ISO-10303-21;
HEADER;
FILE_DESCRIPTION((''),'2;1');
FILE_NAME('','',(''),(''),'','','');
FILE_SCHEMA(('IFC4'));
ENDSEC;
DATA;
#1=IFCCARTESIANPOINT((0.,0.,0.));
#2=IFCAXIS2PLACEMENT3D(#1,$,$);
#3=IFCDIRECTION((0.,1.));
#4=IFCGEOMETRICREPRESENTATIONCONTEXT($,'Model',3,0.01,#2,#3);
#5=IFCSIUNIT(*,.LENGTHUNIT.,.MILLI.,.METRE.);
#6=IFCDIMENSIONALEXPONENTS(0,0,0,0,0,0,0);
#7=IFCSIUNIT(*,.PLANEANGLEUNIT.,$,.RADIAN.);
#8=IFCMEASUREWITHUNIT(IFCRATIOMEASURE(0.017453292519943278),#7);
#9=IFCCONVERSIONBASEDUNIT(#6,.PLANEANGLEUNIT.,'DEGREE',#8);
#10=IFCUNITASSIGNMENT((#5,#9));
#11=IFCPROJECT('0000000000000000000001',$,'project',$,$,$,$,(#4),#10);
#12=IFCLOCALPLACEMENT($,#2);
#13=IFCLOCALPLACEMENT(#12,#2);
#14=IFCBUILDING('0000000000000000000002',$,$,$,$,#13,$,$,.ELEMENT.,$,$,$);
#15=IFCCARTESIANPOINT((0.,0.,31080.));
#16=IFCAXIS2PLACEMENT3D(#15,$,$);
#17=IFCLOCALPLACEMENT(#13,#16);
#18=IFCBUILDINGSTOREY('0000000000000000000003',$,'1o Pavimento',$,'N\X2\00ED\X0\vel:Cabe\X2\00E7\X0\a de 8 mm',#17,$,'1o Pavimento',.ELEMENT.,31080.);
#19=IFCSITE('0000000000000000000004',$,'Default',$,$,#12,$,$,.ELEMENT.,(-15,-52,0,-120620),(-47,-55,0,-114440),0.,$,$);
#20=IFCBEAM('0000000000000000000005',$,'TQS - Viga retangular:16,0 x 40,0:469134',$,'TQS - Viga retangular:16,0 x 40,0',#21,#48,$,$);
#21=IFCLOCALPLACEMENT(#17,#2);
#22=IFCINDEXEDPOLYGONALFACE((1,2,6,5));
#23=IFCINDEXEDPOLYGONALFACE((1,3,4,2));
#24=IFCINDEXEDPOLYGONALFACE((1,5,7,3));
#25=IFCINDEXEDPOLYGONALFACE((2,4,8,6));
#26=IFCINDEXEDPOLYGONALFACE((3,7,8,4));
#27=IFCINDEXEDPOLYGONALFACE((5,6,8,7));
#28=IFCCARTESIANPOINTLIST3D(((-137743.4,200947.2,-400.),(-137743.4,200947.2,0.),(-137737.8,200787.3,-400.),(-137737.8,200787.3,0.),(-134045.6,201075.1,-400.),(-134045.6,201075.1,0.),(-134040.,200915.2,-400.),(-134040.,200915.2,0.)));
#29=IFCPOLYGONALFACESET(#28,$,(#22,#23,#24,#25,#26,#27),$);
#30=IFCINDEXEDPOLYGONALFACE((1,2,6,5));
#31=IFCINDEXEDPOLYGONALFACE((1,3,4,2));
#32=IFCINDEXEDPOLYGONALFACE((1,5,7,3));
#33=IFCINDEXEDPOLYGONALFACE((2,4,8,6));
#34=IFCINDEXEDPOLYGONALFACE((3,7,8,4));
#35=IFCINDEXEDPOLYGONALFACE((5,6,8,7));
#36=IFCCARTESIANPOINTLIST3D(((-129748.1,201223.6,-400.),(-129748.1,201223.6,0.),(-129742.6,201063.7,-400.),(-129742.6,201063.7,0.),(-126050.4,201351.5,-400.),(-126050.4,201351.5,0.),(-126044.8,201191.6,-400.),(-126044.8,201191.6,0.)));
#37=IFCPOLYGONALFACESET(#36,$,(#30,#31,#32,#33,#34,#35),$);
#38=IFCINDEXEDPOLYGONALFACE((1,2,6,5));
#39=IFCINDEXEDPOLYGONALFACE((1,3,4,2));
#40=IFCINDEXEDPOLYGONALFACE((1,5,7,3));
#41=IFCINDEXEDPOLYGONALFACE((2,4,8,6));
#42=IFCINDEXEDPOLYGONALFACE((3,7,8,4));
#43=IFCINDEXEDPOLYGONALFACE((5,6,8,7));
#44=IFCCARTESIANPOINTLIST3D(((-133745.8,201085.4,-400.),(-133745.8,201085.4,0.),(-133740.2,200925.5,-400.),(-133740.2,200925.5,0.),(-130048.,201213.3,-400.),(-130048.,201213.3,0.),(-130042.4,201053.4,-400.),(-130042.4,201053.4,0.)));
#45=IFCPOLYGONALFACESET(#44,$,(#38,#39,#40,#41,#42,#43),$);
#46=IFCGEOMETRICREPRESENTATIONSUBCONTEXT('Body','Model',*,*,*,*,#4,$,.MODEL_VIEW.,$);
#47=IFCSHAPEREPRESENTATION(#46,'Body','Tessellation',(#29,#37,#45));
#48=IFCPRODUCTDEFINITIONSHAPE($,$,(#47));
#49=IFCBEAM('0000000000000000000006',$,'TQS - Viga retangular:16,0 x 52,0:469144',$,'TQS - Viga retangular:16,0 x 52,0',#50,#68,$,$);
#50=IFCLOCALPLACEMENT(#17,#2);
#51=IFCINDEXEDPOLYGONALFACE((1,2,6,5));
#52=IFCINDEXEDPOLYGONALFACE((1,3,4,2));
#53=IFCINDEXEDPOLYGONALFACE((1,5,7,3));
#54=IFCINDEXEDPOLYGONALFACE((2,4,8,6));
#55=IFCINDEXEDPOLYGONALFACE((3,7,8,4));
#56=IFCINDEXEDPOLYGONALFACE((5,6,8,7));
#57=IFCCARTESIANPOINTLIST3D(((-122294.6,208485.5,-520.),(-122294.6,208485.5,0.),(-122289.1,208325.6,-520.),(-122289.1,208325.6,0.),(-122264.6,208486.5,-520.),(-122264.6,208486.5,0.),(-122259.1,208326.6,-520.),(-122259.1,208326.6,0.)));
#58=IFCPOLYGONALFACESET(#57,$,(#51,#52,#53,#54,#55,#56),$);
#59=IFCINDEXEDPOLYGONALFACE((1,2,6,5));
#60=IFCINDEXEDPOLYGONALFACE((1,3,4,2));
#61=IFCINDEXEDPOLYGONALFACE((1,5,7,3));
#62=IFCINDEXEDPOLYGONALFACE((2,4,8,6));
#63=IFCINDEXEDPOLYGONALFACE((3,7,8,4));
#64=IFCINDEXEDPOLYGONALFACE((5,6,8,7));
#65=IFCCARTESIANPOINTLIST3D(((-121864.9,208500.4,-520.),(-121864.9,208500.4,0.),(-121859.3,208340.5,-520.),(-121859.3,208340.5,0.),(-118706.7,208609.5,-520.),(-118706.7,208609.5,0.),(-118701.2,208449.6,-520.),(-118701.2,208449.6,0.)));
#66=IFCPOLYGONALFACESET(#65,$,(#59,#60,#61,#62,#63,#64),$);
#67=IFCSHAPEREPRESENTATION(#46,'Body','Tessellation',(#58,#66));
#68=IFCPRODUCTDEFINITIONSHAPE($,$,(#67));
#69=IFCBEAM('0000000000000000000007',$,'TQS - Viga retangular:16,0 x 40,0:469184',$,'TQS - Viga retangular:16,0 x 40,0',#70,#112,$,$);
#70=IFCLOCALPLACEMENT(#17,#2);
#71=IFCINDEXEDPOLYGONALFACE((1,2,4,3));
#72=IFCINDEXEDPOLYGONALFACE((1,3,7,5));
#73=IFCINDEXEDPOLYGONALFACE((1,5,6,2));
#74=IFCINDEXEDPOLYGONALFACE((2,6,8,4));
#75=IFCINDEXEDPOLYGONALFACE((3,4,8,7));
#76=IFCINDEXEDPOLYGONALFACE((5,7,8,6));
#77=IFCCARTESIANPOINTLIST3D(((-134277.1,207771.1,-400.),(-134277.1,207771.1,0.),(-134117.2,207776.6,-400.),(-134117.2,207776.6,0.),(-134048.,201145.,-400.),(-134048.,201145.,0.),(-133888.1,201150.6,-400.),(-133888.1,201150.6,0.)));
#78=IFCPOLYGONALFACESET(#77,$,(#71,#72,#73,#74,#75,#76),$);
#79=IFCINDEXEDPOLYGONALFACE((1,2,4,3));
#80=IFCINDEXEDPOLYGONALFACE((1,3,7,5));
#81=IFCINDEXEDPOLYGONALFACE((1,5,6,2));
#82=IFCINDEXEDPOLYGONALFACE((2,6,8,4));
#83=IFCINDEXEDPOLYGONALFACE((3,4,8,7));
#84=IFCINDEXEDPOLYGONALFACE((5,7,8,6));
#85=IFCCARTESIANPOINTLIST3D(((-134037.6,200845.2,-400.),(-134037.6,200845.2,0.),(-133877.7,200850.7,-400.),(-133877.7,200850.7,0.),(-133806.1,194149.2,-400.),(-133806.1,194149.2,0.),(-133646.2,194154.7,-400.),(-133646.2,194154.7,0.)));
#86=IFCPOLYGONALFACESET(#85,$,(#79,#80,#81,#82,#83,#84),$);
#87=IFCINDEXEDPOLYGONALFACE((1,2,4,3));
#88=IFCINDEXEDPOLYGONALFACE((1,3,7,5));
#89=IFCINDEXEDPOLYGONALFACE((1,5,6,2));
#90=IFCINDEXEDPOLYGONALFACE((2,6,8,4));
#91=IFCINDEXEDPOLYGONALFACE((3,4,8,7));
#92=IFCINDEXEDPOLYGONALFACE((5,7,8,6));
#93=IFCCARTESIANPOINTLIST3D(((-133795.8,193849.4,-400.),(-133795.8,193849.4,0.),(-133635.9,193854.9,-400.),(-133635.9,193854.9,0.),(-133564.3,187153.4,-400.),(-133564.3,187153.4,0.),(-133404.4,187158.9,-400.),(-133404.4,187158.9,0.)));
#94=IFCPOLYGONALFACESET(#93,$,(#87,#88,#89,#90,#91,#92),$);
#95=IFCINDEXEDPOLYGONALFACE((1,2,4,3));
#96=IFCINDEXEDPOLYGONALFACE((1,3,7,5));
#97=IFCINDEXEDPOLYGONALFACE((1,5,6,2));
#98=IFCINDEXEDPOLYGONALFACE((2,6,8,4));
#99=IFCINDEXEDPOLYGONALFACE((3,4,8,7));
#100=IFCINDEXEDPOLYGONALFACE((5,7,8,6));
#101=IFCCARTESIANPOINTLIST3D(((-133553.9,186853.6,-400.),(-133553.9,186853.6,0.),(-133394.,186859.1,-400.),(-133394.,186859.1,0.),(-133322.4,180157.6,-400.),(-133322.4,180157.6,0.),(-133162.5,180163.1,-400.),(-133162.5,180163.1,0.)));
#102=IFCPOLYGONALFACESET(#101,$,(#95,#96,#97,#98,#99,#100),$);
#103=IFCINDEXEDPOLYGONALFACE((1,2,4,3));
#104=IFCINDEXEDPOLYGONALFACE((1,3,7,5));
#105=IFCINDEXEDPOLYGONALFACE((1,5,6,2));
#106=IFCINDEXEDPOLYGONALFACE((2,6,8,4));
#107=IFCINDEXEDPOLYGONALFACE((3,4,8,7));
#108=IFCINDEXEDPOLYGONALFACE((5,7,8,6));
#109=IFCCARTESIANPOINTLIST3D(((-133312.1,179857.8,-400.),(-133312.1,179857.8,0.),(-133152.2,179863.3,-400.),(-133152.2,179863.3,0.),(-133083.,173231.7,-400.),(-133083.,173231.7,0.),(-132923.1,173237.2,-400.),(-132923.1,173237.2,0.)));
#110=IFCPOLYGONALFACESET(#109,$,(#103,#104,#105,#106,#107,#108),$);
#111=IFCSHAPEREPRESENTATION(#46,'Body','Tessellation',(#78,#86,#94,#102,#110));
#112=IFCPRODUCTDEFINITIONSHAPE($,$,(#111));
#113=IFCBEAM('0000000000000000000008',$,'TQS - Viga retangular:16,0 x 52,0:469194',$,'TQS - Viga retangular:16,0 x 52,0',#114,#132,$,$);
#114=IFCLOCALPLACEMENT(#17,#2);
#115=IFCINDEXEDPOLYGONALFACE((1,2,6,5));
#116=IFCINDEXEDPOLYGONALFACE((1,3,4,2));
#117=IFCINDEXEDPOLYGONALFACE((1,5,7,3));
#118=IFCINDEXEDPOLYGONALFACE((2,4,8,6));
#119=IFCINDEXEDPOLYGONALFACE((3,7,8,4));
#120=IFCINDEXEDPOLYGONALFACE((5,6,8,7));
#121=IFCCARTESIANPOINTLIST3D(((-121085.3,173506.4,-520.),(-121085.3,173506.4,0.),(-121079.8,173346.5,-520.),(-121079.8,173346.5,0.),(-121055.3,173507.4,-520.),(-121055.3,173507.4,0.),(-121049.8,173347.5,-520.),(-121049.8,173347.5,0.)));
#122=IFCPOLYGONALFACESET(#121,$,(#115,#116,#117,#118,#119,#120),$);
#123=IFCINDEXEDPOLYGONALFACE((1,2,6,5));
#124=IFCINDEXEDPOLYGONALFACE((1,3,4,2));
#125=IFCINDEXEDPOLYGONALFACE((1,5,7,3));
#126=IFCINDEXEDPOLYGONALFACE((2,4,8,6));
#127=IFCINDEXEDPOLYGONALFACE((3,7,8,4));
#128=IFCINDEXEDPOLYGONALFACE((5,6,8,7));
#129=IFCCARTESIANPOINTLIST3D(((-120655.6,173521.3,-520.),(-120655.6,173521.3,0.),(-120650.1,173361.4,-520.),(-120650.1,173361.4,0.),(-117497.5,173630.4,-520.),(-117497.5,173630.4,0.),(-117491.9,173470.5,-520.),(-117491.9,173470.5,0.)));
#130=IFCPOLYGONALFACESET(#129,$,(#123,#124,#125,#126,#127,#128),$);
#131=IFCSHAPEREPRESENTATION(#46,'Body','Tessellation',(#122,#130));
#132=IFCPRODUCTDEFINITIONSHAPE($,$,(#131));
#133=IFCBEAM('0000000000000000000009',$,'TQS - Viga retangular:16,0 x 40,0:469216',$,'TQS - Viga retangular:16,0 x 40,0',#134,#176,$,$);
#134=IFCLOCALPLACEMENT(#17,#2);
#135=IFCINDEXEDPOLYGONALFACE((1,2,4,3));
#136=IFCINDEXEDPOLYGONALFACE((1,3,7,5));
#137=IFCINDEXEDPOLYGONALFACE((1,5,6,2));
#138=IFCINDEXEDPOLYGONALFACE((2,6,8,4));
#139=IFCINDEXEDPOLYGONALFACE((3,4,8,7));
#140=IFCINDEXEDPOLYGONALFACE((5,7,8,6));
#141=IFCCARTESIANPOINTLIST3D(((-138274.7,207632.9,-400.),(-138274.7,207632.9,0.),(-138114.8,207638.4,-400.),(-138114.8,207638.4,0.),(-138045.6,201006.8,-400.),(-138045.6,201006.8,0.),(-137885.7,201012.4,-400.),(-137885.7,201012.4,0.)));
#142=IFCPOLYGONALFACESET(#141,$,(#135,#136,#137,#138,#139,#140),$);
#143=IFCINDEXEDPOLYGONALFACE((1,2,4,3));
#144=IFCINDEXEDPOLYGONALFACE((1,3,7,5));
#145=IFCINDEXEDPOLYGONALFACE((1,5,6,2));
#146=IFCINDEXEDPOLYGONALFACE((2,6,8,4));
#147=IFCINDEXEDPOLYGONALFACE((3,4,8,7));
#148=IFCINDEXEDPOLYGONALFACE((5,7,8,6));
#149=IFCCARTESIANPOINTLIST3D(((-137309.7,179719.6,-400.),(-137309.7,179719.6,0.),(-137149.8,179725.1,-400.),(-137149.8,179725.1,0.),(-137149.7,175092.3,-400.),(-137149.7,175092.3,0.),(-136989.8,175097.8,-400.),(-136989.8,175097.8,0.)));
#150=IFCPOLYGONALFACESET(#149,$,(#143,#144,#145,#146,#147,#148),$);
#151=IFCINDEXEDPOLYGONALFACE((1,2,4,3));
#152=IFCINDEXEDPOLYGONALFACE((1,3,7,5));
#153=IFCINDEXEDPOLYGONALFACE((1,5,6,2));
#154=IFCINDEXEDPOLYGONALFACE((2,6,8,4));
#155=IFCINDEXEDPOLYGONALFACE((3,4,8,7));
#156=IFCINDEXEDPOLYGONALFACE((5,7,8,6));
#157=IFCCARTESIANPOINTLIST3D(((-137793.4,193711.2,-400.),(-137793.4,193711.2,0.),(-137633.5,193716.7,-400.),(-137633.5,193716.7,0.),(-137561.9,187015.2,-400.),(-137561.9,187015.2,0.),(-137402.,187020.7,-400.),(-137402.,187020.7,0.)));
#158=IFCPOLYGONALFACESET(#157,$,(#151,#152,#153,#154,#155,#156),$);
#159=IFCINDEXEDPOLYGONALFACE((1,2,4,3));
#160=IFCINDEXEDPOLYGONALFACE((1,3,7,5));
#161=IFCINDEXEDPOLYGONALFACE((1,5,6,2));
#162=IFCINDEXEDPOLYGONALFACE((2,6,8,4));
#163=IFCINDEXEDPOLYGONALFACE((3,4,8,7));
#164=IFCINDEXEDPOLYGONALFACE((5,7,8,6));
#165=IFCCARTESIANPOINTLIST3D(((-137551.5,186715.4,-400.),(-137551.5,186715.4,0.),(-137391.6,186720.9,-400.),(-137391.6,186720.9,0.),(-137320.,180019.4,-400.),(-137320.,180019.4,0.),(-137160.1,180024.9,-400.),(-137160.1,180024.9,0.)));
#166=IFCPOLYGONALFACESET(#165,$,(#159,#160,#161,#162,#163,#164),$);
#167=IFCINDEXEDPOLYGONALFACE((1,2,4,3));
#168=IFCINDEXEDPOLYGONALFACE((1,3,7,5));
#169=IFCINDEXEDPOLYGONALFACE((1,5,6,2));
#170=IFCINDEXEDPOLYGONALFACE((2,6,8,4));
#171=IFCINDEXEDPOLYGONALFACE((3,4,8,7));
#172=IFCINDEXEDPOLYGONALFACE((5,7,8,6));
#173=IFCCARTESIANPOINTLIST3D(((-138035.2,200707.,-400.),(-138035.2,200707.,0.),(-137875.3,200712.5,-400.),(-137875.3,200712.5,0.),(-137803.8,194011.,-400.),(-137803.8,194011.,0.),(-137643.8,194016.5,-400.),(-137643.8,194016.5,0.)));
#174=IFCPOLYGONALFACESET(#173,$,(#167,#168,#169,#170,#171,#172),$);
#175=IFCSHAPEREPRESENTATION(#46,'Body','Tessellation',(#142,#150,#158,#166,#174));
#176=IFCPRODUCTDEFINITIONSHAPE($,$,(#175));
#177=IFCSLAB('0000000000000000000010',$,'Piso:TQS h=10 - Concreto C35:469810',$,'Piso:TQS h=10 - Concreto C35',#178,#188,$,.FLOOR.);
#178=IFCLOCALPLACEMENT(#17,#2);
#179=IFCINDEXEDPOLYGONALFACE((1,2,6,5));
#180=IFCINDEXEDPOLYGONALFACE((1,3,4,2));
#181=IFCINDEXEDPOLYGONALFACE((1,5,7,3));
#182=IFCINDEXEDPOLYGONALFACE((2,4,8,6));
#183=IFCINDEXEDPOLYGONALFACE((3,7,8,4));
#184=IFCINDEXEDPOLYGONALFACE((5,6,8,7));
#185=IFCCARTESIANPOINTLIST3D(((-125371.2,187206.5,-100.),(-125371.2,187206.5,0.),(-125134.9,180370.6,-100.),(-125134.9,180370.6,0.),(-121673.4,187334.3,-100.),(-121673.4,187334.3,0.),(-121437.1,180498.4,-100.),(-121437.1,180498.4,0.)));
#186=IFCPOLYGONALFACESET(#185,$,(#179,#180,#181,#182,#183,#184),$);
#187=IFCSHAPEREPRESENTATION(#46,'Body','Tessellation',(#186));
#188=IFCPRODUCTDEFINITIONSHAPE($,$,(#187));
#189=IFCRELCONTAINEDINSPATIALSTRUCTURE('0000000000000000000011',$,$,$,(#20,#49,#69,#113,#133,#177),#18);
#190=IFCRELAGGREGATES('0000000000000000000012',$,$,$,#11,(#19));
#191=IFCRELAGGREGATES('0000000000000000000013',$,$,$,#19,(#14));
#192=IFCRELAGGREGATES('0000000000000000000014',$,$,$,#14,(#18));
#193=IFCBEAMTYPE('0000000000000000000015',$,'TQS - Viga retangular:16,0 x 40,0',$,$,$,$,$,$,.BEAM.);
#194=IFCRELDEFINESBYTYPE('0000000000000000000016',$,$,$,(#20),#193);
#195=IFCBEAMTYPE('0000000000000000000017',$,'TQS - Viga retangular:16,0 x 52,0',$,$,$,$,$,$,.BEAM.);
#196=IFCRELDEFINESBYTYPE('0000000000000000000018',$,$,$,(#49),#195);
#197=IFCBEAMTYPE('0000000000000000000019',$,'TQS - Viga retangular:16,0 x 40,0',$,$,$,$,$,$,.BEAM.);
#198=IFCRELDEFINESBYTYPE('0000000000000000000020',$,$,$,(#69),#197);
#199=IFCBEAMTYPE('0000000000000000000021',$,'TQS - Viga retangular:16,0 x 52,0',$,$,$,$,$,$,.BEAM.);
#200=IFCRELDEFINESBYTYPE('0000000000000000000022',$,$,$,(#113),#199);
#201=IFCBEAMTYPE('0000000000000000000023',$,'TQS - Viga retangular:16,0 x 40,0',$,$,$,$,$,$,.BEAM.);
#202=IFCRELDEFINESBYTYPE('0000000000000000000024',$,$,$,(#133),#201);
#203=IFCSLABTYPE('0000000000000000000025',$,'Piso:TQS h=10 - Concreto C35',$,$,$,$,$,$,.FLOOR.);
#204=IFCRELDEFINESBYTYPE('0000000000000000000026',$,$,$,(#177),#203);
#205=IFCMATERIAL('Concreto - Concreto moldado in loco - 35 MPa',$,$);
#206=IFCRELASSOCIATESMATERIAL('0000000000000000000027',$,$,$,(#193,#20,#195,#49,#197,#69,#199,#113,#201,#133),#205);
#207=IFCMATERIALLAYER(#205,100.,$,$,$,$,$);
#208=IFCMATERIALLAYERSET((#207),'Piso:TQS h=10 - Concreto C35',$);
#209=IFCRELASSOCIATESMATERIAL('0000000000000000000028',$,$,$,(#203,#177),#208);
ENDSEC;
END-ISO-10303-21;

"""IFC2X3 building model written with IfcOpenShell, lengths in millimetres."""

from ifc_helpers import new_model, entity, si_unit, converted_unit, direction, frame, frame_2d, origin, place, context, subcontext, project, spatial, rectangle, extrude, source, transform, mapped, material, layer, layer_set, layer_usage, type_object, type_shapes, element, save


model = new_model("IFC2X3")

# Units and contexts
model_context = context("Model", 3, precision=0.01, world=origin(), true_north=direction((0.0, 1.0)))
body_context = subcontext(model_context, "Body", "Model", "MODEL_VIEW")
ifc_project = project(units=[si_unit("LENGTHUNIT", "METRE", prefix="MILLI"), converted_unit("PLANEANGLEUNIT", "DEGREE", entity("IfcRatioMeasure", 0.017453292519943278), si_unit("PLANEANGLEUNIT", "RADIAN"), dimensions=[0, 0, 0, 0, 0, 0, 0])], contexts=[model_context])

# Site, building, storey
site_placement = place(None, origin())
site = spatial("IfcSite", under=ifc_project, at=site_placement, Name="Default", CompositionType="ELEMENT", RefLatitude=(-15, -52, 0, -120620), RefLongitude=(-47, -55, 0, -114440), RefElevation=0.0)
building_placement = place(site_placement, origin())
building = spatial("IfcBuilding", under=site, at=building_placement, CompositionType="ELEMENT")
storey_placement = place(building_placement, frame((0.0, 0.0, 31080.0)))
storey = spatial("IfcBuildingStorey", under=building, at=storey_placement, Name="1o Pavimento", ObjectType="Nível:Cabeça de 8 mm", LongName="1o Pavimento", CompositionType="ELEMENT", Elevation=31080.0)

# Shared definitions
ifc_material = material(Name="Concreto - Concreto moldado in loco - 35 MPa")

# Beams
beam_type_1 = type_object("IfcBeamType", Name="TQS - Viga retangular:16,0 x 40,0", PredefinedType="BEAM", material=ifc_material)
shared_shape_1 = source(origin(), body_context, "Body", "SweptSolid", [
    extrude(rectangle(XDim=400.0, YDim=160.0, at=frame_2d((0.0, 0.0), x_axis=(1.0, 0.0))), frame((-134042.8, 200995.1, 30880.0), z_axis=(-0.999403, -0.034551, 0.0), x_axis=(0.0, 0.0, -1.0)), (0.0, 0.0, 1.0), 3700.0),
    extrude(rectangle(XDim=400.0, YDim=160.0, at=frame_2d((0.0, 0.0), x_axis=(1.0, 0.0))), frame((-126047.6, 201271.5, 30880.0), z_axis=(-0.999403, -0.034551, 0.0), x_axis=(0.0, 0.0, -1.0)), (0.0, 0.0, 1.0), 3700.0),
    extrude(rectangle(XDim=400.0, YDim=160.0, at=frame_2d((0.0, 0.0), x_axis=(1.0, 0.0))), frame((-130045.2, 201133.3, 30880.0), z_axis=(-0.999403, -0.034551, 0.0), x_axis=(0.0, 0.0, -1.0)), (0.0, 0.0, 1.0), 3700.0),
])
type_shapes(beam_type_1, [shared_shape_1])
beam_1_placement = place(storey_placement, frame((0.0, 0.0, -31080.0)))
element("IfcBeam", 1, at=beam_1_placement, inside=storey, type_object=beam_type_1, material=ifc_material, Name="TQS - Viga retangular:16,0 x 40,0:469134", ObjectType="TQS - Viga retangular:16,0 x 40,0", context=body_context, shape_type="MappedRepresentation", body=[
    mapped(shared_shape_1, transform((0.0, 0.0, 0.0), scale=1.0)),
])
beam_type_2 = type_object("IfcBeamType", Name="TQS - Viga retangular:16,0 x 52,0", PredefinedType="BEAM", material=ifc_material)
shared_shape_2 = source(origin(), body_context, "Body", "SweptSolid", [
    extrude(rectangle(XDim=520.0, YDim=160.0, at=frame_2d((0.0, 0.0), x_axis=(1.0, 0.0))), frame((-122261.9, 208406.6, 30820.0), z_axis=(-0.999403, -0.034551, 0.0), x_axis=(0.0, 0.0, -1.0)), (0.0, 0.0, 1.0), 30.0),
    extrude(rectangle(XDim=520.0, YDim=160.0, at=frame_2d((0.0, 0.0), x_axis=(1.0, 0.0))), frame((-118704.0, 208529.6, 30820.0), z_axis=(-0.999403, -0.034551, 0.0), x_axis=(0.0, 0.0, -1.0)), (0.0, 0.0, 1.0), 3160.0),
])
type_shapes(beam_type_2, [shared_shape_2])
beam_2_placement = place(storey_placement, frame((0.0, 0.0, -31080.0)))
element("IfcBeam", 2, at=beam_2_placement, inside=storey, type_object=beam_type_2, material=ifc_material, Name="TQS - Viga retangular:16,0 x 52,0:469144", ObjectType="TQS - Viga retangular:16,0 x 52,0", context=body_context, shape_type="MappedRepresentation", body=[
    mapped(shared_shape_2, transform((0.0, 0.0, 0.0), scale=1.0)),
])
beam_type_3 = type_object("IfcBeamType", Name="TQS - Viga retangular:16,0 x 40,0", PredefinedType="BEAM", material=ifc_material)
shared_shape_3 = source(origin(), body_context, "Body", "SweptSolid", [
    extrude(rectangle(XDim=400.0, YDim=160.0, at=frame_2d((0.0, 0.0), x_axis=(1.0, 0.0))), frame((-133968.0, 201147.8, 30880.0), z_axis=(-0.034551, 0.999403, 0.0), x_axis=(0.0, 0.0, 1.0)), (0.0, 0.0, 1.0), 6630.0),
    extrude(rectangle(XDim=400.0, YDim=160.0, at=frame_2d((0.0, 0.0), x_axis=(1.0, 0.0))), frame((-133726.2, 194152.0, 30880.0), z_axis=(-0.034551, 0.999403, 0.0), x_axis=(0.0, 0.0, 1.0)), (0.0, 0.0, 1.0), 6700.0),
    extrude(rectangle(XDim=400.0, YDim=160.0, at=frame_2d((0.0, 0.0), x_axis=(1.0, 0.0))), frame((-133484.3, 187156.2, 30880.0), z_axis=(-0.034551, 0.999403, 0.0), x_axis=(0.0, 0.0, 1.0)), (0.0, 0.0, 1.0), 6700.0),
    extrude(rectangle(XDim=400.0, YDim=160.0, at=frame_2d((0.0, 0.0), x_axis=(1.0, 0.0))), frame((-133242.5, 180160.3, 30880.0), z_axis=(-0.034551, 0.999403, 0.0), x_axis=(0.0, 0.0, 1.0)), (0.0, 0.0, 1.0), 6700.0),
    extrude(rectangle(XDim=400.0, YDim=160.0, at=frame_2d((0.0, 0.0), x_axis=(1.0, 0.0))), frame((-133003.0, 173234.5, 30880.0), z_axis=(-0.034551, 0.999403, 0.0), x_axis=(0.0, 0.0, 1.0)), (0.0, 0.0, 1.0), 6630.0),
])
type_shapes(beam_type_3, [shared_shape_3])
beam_3_placement = place(storey_placement, frame((0.0, 0.0, -31080.0)))
element("IfcBeam", 3, at=beam_3_placement, inside=storey, type_object=beam_type_3, material=ifc_material, Name="TQS - Viga retangular:16,0 x 40,0:469184", ObjectType="TQS - Viga retangular:16,0 x 40,0", context=body_context, shape_type="MappedRepresentation", body=[
    mapped(shared_shape_3, transform((0.0, 0.0, 0.0), scale=1.0)),
])
beam_type_4 = type_object("IfcBeamType", Name="TQS - Viga retangular:16,0 x 52,0", PredefinedType="BEAM", material=ifc_material)
shared_shape_4 = source(origin(), body_context, "Body", "SweptSolid", [
    extrude(rectangle(XDim=520.0, YDim=160.0, at=frame_2d((0.0, 0.0), x_axis=(1.0, 0.0))), frame((-121052.6, 173427.5, 30820.0), z_axis=(-0.999403, -0.034551, 0.0), x_axis=(0.0, 0.0, -1.0)), (0.0, 0.0, 1.0), 30.0),
    extrude(rectangle(XDim=520.0, YDim=160.0, at=frame_2d((0.0, 0.0), x_axis=(1.0, 0.0))), frame((-117494.7, 173550.5, 30820.0), z_axis=(-0.999403, -0.034551, 0.0), x_axis=(0.0, 0.0, -1.0)), (0.0, 0.0, 1.0), 3160.0),
])
type_shapes(beam_type_4, [shared_shape_4])
beam_4_placement = place(storey_placement, frame((0.0, 0.0, -31080.0)))
element("IfcBeam", 4, at=beam_4_placement, inside=storey, type_object=beam_type_4, material=ifc_material, Name="TQS - Viga retangular:16,0 x 52,0:469194", ObjectType="TQS - Viga retangular:16,0 x 52,0", context=body_context, shape_type="MappedRepresentation", body=[
    mapped(shared_shape_4, transform((0.0, 0.0, 0.0), scale=1.0)),
])
beam_type_5 = type_object("IfcBeamType", Name="TQS - Viga retangular:16,0 x 40,0", PredefinedType="BEAM", material=ifc_material)
shared_shape_5 = source(origin(), body_context, "Body", "SweptSolid", [
    extrude(rectangle(XDim=400.0, YDim=160.0, at=frame_2d((0.0, 0.0), x_axis=(1.0, 0.0))), frame((-137965.7, 201009.6, 30880.0), z_axis=(-0.034551, 0.999403, 0.0), x_axis=(0.0, 0.0, 1.0)), (0.0, 0.0, 1.0), 6630.0),
    extrude(rectangle(XDim=400.0, YDim=160.0, at=frame_2d((0.0, 0.0), x_axis=(1.0, 0.0))), frame((-137069.8, 175095.1, 30880.0), z_axis=(-0.034551, 0.999403, 0.0), x_axis=(0.0, 0.0, 1.0)), (0.0, 0.0, 1.0), 4630.0),
    extrude(rectangle(XDim=400.0, YDim=160.0, at=frame_2d((0.0, 0.0), x_axis=(1.0, 0.0))), frame((-137481.9, 187018.0, 30880.0), z_axis=(-0.034551, 0.999403, 0.0), x_axis=(0.0, 0.0, 1.0)), (0.0, 0.0, 1.0), 6700.0),
    extrude(rectangle(XDim=400.0, YDim=160.0, at=frame_2d((0.0, 0.0), x_axis=(1.0, 0.0))), frame((-137240.1, 180022.1, 30880.0), z_axis=(-0.034551, 0.999403, 0.0), x_axis=(0.0, 0.0, 1.0)), (0.0, 0.0, 1.0), 6700.0),
    extrude(rectangle(XDim=400.0, YDim=160.0, at=frame_2d((0.0, 0.0), x_axis=(1.0, 0.0))), frame((-137723.8, 194013.8, 30880.0), z_axis=(-0.034551, 0.999403, 0.0), x_axis=(0.0, 0.0, 1.0)), (0.0, 0.0, 1.0), 6700.0),
])
type_shapes(beam_type_5, [shared_shape_5])
beam_5_placement = place(storey_placement, frame((0.0, 0.0, -31080.0)))
element("IfcBeam", 5, at=beam_5_placement, inside=storey, type_object=beam_type_5, material=ifc_material, Name="TQS - Viga retangular:16,0 x 40,0:469216", ObjectType="TQS - Viga retangular:16,0 x 40,0", context=body_context, shape_type="MappedRepresentation", body=[
    mapped(shared_shape_5, transform((0.0, 0.0, 0.0), scale=1.0)),
])

# Slab
ifc_layer = layer(ifc_material, 100.0)
ifc_layer_set = layer_set([ifc_layer], Name="Piso:TQS h=10 - Concreto C35")
ifc_layer_usage_1 = layer_usage(ifc_layer_set, "AXIS3", "POSITIVE", 0.0)
slab_type_1 = type_object("IfcSlabType", Name="Piso:TQS h=10 - Concreto C35", PredefinedType="FLOOR", material=ifc_layer_set)
slab_1_placement = place(storey_placement, origin())
element("IfcSlab", 6, at=slab_1_placement, inside=storey, type_object=slab_type_1, material=ifc_layer_usage_1, Name="Piso:TQS h=10 - Concreto C35:469810", ObjectType="Piso:TQS h=10 - Concreto C35", PredefinedType="FLOOR", context=body_context, shape_type="SweptSolid", body=[
    extrude(rectangle(XDim=6840.0, YDim=3700.0, at=frame_2d((0.0, 0.0), x_axis=(1.0, 0.0))), frame((-123404.2, 183852.5, 0.0), z_axis=(0.0, 0.0, -1.0), x_axis=(0.034551, -0.999403, 0.0)), (0.0, 0.0, 1.0), 100.0),
])

save(model, "model.ifc")
